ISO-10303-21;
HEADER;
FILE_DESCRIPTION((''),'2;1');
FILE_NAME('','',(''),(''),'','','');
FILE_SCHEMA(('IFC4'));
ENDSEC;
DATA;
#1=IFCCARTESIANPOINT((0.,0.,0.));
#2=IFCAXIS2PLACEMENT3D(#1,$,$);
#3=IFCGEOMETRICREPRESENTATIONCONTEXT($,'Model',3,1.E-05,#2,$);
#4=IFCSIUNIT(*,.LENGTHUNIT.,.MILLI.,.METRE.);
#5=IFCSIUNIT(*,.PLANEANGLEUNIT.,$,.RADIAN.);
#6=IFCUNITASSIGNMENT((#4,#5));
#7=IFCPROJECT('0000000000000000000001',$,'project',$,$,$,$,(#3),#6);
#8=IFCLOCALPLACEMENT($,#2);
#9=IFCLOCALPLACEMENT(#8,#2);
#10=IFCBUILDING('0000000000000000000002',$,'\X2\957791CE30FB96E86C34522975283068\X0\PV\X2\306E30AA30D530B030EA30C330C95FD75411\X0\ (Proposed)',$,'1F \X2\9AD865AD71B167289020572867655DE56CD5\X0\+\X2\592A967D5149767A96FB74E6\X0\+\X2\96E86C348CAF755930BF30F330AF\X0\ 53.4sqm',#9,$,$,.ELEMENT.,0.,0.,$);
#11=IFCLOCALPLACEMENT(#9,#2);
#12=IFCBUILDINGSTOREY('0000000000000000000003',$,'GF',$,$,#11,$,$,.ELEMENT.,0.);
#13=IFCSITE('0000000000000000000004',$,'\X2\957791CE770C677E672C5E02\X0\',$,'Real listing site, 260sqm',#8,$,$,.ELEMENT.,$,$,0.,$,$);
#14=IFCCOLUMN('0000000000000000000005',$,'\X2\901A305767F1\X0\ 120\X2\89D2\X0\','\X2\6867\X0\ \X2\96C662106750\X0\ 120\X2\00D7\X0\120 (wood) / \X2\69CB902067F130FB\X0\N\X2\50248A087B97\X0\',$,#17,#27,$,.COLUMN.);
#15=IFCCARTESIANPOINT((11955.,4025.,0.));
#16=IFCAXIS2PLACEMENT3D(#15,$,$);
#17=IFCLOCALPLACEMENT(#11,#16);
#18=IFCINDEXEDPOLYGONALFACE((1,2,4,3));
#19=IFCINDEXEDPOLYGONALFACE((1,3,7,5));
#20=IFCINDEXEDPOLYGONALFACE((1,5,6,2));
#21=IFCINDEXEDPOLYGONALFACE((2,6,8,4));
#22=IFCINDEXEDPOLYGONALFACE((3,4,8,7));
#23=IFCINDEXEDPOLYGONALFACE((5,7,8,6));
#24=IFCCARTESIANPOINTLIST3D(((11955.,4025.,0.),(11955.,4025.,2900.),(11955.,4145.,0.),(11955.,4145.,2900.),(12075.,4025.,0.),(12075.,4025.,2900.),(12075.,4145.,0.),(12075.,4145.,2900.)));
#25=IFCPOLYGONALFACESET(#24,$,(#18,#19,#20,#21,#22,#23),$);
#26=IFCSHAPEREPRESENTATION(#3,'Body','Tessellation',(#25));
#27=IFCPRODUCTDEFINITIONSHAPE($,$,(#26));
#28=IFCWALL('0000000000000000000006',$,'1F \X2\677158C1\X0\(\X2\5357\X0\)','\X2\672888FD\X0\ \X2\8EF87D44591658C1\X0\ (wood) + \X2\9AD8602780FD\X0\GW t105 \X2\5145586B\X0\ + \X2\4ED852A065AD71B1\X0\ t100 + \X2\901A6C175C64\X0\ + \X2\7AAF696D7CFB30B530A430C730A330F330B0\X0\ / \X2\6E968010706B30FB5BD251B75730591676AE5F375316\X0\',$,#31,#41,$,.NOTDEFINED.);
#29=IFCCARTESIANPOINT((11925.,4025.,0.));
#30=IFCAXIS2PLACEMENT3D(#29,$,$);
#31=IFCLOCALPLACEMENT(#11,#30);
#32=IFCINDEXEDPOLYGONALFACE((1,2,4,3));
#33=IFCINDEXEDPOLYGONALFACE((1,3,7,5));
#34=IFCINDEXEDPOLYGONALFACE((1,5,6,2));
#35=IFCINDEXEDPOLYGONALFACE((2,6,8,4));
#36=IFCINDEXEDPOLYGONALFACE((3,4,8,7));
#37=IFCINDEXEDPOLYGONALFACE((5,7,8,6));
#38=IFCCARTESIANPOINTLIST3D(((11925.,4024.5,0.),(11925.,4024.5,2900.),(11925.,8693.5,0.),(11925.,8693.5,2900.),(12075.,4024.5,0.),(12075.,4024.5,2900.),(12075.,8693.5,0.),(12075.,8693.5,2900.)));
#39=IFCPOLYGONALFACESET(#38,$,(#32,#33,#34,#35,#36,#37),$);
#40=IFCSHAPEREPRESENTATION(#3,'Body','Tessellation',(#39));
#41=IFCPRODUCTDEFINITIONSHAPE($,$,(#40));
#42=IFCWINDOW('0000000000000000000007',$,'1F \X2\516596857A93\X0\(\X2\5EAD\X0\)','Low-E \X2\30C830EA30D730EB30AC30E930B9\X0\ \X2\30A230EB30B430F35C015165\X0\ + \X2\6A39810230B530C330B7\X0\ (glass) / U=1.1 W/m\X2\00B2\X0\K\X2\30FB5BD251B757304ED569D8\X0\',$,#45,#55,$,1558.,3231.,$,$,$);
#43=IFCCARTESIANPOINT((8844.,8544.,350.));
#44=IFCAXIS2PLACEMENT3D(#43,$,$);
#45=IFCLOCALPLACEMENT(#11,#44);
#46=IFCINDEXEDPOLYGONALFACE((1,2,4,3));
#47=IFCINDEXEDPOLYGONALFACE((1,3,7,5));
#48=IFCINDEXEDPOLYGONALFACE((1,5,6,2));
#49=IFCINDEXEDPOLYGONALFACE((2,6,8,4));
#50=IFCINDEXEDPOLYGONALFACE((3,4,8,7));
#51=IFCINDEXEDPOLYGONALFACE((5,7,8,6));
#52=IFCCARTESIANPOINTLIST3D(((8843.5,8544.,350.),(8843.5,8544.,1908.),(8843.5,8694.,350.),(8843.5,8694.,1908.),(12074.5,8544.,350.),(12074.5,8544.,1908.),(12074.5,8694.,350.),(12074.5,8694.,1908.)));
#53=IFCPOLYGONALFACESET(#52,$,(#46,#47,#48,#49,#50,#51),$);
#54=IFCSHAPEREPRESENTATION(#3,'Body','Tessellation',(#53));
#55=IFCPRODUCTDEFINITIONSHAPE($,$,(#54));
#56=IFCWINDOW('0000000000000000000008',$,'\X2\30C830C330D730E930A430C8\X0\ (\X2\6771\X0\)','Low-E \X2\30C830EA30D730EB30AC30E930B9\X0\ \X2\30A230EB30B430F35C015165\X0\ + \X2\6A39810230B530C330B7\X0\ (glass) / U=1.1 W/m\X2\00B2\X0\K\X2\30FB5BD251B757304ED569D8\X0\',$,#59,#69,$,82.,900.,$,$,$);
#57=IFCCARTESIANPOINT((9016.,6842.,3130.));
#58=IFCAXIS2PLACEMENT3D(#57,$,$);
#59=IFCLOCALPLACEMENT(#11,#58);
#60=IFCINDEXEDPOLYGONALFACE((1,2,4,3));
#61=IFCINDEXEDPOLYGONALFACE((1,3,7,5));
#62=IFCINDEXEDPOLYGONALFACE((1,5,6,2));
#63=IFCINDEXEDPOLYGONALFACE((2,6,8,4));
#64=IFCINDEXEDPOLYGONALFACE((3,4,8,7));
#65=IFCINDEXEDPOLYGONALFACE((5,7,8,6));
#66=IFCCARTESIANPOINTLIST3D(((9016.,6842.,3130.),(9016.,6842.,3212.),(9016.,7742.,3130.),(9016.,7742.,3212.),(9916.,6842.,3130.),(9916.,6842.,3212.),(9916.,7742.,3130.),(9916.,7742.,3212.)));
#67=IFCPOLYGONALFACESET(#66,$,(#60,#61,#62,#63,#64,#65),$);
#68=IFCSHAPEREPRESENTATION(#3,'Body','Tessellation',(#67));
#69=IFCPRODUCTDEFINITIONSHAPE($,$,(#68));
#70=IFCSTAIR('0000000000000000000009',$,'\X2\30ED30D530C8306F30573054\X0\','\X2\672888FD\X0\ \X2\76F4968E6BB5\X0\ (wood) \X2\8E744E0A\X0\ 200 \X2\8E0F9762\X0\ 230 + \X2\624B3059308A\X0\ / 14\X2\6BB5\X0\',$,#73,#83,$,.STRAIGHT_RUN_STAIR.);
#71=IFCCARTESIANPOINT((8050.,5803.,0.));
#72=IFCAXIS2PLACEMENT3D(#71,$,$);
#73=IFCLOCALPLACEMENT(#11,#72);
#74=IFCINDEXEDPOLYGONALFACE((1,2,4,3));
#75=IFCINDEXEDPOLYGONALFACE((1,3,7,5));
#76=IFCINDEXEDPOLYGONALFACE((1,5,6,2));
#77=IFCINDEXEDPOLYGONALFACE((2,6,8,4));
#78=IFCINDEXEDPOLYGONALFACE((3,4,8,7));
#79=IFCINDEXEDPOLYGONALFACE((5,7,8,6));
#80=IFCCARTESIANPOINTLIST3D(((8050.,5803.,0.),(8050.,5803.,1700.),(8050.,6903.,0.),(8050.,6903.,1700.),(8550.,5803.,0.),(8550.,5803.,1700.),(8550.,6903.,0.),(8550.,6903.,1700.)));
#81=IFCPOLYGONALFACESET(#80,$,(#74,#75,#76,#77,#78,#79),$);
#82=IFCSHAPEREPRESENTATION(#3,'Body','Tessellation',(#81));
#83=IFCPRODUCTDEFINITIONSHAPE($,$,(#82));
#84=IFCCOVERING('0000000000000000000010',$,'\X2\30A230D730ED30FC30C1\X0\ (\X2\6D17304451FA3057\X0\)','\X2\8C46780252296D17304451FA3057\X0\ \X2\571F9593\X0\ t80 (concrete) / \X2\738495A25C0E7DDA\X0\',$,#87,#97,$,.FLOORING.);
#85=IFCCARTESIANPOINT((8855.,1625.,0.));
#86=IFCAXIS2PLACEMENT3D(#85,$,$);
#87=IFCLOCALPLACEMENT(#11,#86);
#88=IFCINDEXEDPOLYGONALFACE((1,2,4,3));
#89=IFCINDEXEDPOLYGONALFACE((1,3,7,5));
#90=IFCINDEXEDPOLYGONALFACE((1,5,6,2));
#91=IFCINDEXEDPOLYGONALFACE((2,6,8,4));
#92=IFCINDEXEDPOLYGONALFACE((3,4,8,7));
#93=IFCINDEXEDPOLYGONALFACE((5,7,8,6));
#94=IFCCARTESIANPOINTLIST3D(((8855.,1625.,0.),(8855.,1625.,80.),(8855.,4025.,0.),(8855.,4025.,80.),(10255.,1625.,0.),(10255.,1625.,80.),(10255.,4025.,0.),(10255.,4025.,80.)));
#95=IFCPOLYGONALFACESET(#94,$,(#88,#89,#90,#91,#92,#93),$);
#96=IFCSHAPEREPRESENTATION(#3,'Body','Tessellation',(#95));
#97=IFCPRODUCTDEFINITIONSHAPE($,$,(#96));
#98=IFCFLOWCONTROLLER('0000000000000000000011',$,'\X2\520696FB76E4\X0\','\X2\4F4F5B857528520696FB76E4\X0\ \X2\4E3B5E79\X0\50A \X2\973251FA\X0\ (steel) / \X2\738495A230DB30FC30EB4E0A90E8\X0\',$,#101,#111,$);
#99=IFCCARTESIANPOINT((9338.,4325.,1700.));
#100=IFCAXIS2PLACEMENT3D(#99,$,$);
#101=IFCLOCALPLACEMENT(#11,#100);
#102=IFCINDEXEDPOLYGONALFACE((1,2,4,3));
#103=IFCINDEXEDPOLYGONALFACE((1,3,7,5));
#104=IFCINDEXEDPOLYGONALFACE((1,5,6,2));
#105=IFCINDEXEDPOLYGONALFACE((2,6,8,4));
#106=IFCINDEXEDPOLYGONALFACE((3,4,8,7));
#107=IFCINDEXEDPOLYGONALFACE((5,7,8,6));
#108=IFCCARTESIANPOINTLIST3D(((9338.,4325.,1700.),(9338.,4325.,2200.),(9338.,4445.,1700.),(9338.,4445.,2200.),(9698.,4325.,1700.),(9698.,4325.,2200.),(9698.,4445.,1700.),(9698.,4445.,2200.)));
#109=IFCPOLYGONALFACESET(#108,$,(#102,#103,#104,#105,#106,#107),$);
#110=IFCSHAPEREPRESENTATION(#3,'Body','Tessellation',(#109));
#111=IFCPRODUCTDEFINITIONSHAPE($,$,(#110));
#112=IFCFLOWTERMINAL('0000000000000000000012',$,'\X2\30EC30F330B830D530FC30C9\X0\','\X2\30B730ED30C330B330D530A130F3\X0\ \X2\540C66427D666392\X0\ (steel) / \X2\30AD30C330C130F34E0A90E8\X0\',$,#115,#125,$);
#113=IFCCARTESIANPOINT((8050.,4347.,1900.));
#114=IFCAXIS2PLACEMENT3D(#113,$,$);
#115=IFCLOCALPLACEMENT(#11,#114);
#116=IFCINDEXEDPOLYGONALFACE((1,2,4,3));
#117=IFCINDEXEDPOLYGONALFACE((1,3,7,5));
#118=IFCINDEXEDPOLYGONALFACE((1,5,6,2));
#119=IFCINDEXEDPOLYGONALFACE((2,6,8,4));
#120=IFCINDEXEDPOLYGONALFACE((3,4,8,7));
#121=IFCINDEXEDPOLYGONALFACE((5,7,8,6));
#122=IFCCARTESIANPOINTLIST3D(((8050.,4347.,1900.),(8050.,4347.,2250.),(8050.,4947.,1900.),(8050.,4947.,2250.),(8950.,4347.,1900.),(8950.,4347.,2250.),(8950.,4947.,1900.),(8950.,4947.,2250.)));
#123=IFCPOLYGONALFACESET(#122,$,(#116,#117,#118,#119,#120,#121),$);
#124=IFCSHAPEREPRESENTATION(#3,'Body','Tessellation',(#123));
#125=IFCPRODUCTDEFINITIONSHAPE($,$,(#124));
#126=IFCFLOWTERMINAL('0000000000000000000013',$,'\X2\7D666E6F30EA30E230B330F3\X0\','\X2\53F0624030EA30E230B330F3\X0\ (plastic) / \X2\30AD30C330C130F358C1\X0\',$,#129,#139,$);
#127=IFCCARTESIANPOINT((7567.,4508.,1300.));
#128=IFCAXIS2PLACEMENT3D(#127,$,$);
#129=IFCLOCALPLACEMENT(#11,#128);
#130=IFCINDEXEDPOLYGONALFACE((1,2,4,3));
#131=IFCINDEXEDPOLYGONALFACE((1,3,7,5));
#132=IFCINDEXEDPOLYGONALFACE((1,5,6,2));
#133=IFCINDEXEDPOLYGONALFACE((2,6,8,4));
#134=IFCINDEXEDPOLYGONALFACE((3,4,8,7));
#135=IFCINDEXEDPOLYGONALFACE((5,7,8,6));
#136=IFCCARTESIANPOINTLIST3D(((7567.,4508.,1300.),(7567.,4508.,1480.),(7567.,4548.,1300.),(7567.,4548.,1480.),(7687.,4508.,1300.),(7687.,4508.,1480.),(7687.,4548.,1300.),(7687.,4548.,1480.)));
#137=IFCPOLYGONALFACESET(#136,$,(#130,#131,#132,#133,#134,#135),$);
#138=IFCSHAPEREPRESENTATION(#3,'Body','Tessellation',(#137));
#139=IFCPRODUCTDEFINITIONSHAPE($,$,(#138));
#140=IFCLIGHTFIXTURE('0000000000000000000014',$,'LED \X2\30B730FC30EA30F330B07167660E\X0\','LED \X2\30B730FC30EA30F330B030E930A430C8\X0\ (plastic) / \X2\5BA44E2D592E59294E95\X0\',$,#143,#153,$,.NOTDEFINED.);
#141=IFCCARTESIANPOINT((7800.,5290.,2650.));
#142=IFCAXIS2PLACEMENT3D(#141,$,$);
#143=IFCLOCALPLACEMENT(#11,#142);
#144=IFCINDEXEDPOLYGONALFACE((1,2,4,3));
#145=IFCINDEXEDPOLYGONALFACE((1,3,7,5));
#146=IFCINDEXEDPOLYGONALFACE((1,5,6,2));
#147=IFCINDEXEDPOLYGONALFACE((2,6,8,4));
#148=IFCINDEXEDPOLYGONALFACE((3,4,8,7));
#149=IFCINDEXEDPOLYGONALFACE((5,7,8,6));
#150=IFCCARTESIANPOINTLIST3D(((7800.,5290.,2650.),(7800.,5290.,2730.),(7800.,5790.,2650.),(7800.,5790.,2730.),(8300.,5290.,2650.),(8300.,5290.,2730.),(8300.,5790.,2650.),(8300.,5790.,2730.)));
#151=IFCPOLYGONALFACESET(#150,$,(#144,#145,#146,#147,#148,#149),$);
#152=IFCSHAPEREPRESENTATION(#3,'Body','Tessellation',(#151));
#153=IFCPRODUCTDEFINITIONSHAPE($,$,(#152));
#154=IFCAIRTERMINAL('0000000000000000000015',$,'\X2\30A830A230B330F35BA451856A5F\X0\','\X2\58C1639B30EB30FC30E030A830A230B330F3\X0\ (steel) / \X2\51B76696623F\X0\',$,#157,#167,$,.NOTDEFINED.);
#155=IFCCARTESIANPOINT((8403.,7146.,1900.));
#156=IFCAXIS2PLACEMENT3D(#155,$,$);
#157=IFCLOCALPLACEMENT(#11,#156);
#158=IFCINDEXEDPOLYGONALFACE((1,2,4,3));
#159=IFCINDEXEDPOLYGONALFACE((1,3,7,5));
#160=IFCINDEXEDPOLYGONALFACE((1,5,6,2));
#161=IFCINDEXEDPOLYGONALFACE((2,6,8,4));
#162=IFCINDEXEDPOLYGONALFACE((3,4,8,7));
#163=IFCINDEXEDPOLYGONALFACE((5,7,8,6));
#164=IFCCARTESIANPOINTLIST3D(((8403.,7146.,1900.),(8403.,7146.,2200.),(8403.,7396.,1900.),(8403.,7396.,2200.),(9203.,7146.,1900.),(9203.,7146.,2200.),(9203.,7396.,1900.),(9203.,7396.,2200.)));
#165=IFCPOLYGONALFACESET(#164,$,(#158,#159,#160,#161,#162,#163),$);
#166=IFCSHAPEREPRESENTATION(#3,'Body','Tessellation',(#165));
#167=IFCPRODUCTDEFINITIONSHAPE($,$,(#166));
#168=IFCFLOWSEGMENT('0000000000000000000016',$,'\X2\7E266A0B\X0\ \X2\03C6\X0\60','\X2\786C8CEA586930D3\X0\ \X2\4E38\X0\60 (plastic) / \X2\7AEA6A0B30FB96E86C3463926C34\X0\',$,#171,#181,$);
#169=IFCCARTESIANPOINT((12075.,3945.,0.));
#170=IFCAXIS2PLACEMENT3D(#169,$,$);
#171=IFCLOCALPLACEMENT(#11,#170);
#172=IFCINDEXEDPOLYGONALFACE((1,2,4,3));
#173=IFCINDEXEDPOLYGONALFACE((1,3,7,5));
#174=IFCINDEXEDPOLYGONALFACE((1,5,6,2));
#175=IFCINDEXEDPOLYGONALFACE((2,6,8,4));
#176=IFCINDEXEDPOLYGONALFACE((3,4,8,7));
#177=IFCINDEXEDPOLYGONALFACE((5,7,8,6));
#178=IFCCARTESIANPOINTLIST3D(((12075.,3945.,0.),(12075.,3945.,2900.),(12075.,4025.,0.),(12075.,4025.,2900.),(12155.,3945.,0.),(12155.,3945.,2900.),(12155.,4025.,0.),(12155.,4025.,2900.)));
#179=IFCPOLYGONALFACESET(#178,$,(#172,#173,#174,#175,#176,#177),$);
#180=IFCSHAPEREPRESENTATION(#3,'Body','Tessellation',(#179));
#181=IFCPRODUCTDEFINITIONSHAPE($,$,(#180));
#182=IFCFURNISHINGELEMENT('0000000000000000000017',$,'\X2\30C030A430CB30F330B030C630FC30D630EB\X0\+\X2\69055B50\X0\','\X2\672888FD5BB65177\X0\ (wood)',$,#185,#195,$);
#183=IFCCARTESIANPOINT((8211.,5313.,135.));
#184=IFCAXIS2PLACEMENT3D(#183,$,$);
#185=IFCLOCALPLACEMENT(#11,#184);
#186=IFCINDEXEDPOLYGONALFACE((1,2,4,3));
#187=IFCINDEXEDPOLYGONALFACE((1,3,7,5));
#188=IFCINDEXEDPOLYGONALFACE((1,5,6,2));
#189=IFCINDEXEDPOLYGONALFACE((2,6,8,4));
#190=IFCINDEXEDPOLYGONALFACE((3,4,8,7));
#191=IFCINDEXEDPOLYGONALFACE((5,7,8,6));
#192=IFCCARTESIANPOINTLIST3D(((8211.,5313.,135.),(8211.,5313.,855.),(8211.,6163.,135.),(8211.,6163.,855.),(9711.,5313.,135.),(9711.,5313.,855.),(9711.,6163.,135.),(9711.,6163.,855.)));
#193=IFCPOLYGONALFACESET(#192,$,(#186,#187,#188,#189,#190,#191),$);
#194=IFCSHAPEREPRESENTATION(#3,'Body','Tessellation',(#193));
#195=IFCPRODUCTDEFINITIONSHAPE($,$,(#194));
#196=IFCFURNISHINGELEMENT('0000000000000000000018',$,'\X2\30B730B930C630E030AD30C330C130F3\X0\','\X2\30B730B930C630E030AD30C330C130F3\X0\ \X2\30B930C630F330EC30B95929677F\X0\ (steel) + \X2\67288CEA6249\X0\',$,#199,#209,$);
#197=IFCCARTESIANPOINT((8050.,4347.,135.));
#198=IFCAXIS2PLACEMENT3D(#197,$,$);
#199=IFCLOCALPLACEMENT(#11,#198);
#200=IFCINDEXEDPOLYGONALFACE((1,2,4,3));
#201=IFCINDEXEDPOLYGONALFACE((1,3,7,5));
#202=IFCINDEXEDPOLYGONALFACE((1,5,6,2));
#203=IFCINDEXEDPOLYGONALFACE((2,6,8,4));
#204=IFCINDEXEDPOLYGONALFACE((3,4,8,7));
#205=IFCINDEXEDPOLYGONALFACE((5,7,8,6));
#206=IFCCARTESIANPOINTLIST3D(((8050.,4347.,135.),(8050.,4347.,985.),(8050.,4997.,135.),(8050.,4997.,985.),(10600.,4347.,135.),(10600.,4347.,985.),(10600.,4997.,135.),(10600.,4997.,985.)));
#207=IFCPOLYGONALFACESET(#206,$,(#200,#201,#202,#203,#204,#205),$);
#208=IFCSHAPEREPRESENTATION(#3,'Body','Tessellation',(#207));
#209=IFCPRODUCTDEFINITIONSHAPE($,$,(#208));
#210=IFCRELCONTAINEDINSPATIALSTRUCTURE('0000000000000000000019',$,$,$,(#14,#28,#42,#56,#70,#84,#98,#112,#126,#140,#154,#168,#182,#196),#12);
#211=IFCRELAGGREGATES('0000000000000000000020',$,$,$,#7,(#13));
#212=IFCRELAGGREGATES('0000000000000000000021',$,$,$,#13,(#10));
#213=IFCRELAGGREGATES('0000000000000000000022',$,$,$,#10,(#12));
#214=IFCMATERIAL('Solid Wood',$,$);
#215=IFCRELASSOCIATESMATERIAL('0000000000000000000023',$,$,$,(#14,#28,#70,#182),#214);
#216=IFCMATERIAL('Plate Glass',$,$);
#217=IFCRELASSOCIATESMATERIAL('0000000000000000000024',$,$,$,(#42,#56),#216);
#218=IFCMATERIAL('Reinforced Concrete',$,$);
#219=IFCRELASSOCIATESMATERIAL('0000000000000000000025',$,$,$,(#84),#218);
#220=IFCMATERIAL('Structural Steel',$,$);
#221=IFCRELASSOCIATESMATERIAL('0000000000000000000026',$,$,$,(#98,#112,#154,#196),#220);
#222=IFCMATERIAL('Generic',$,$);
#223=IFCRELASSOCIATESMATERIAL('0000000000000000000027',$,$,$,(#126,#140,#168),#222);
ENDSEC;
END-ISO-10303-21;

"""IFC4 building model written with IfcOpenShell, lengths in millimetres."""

from ifc_helpers import new_model, si_unit, frame, frame_2d, origin, place, context, project, spatial, rectangle, extrude, material, element, fill, save


model = new_model("IFC4")

# Units and contexts
model_context = context("Model", 3, precision=1e-05, world=origin())
ifc_project = project(units=[si_unit("LENGTHUNIT", "METRE", prefix="MILLI"), si_unit("PLANEANGLEUNIT", "RADIAN")], contexts=[model_context])

# Site, building, storey
site_placement = place(None, origin())
site = spatial("IfcSite", under=ifc_project, at=site_placement, Name="長野県松本市", ObjectType="Real listing site, 260sqm", CompositionType="ELEMENT", RefElevation=0.0)
building_placement = place(site_placement, origin())
building = spatial("IfcBuilding", under=site, at=building_placement, Name="長野・雨水利用とPVのオフグリッド志向 (Proposed)", ObjectType="1F 高断熱木造在来工法+太陽光発電瓦+雨水貯留タンク 53.4sqm", CompositionType="ELEMENT", ElevationOfRefHeight=0.0, ElevationOfTerrain=0.0)
storey_placement = place(building_placement, origin())
storey = spatial("IfcBuildingStorey", under=building, at=storey_placement, Name="GF", CompositionType="ELEMENT", Elevation=0.0)

# Column
ifc_material_1 = material(Name="Solid Wood")
column_1_placement = place(storey_placement, frame((11955.0, 4025.0, 0.0)))
element("IfcColumn", 1, at=column_1_placement, inside=storey, material=ifc_material_1, Name="通し柱 120角", Description="桧 集成材 120×120 (wood) / 構造柱・N値計算", PredefinedType="COLUMN", context=model_context, shape_type="SweptSolid", body=[
    extrude(rectangle(XDim=120.0, YDim=120.0, at=frame_2d((60.0, 60.0))), frame((11955.0, 4025.0, 0.0)), (0.0, 0.0, 1.0), 2900.0),
])

# Wall, opening, window
wall_1_placement = place(storey_placement, frame((11925.0, 4025.0, 0.0)))
wall_1 = element("IfcWall", 2, at=wall_1_placement, inside=storey, material=ifc_material_1, Name="1F 東壁(南)", Description="木製 軸組外壁 (wood) + 高性能GW t105 充填 + 付加断熱 t100 + 通気層 + 窯業系サイディング / 準耐火・寒冷地外皮強化", PredefinedType="NOTDEFINED", context=model_context, shape_type="SweptSolid", body=[
    extrude(rectangle(XDim=150.0, YDim=4669.0, at=frame_2d((75.0, 2334.0))), frame((11925.0, 4025.0, 0.0)), (0.0, 0.0, 1.0), 2900.0),
])
opening_1_placement = place(storey_placement, frame((8844.0, 8544.0, 350.0)))
opening_1 = element("IfcOpeningElement", 3, at=opening_1_placement, cuts=wall_1, PredefinedType="NOTDEFINED", context=model_context, shape_type="SweptSolid", body=[
    extrude(rectangle(XDim=3231.0, YDim=150.0, at=frame_2d((1615.0, 75.0))), frame((8844.0, 8544.0, 350.0)), (0.0, 0.0, 1.0), 1558.0),
])
ifc_material_2 = material(Name="Plate Glass")
window_1_placement = place(storey_placement, frame((8844.0, 8544.0, 350.0)))
window_1 = element("IfcWindow", 4, at=window_1_placement, inside=storey, material=ifc_material_2, Name="1F 入隅窓(庭)", Description="Low-E トリプルガラス アルゴン封入 + 樹脂サッシ (glass) / U=1.1 W/m²K・寒冷地仕様", OverallHeight=1558.0, OverallWidth=3231.0, context=model_context, shape_type="SweptSolid", body=[
    extrude(rectangle(XDim=3231.0, YDim=150.0, at=frame_2d((1615.0, 75.0))), frame((8844.0, 8544.0, 350.0)), (0.0, 0.0, 1.0), 1558.0),
])
fill(opening_1, window_1)

# Window
window_2_placement = place(storey_placement, frame((9016.0, 6842.0, 3130.0)))
element("IfcWindow", 5, at=window_2_placement, inside=storey, material=ifc_material_2, Name="トップライト (東)", Description="Low-E トリプルガラス アルゴン封入 + 樹脂サッシ (glass) / U=1.1 W/m²K・寒冷地仕様", OverallHeight=82.0, OverallWidth=900.0, context=model_context, shape_type="SweptSolid", body=[
    extrude(rectangle(XDim=900.0, YDim=900.0, at=frame_2d((450.0, 450.0))), frame((9016.0, 6842.0, 3130.0)), (0.0, 0.0, 1.0), 82.0),
])

# Stair
stair_placement = place(storey_placement, frame((8050.0, 5803.0, 0.0)))
element("IfcStair", 6, at=stair_placement, inside=storey, material=ifc_material_1, Name="ロフトはしご", Description="木製 直階段 (wood) 蹴上 200 踏面 230 + 手すり / 14段", PredefinedType="STRAIGHT_RUN_STAIR", context=model_context, shape_type="SweptSolid", body=[
    extrude(rectangle(XDim=500.0, YDim=1100.0, at=frame_2d((250.0, 550.0))), frame((8050.0, 5803.0, 0.0)), (0.0, 0.0, 1.0), 1700.0),
])

# Covering
ifc_material_3 = material(Name="Reinforced Concrete")
covering_placement = place(storey_placement, frame((8855.0, 1625.0, 0.0)))
element("IfcCovering", 7, at=covering_placement, inside=storey, material=ifc_material_3, Name="アプローチ (洗い出し)", Description="豆砂利洗い出し 土間 t80 (concrete) / 玄関導線", PredefinedType="FLOORING", context=model_context, shape_type="SweptSolid", body=[
    extrude(rectangle(XDim=1400.0, YDim=2400.0, at=frame_2d((700.0, 1200.0))), frame((8855.0, 1625.0, 0.0)), (0.0, 0.0, 1.0), 80.0),
])

# Flow controller
ifc_material_4 = material(Name="Structural Steel")
flow_controller_placement = place(storey_placement, frame((9338.0, 4325.0, 1700.0)))
element("IfcFlowController", 8, at=flow_controller_placement, inside=storey, material=ifc_material_4, Name="分電盤", Description="住宅用分電盤 主幹50A 露出 (steel) / 玄関ホール上部", context=model_context, shape_type="SweptSolid", body=[
    extrude(rectangle(XDim=360.0, YDim=120.0, at=frame_2d((180.0, 60.0))), frame((9338.0, 4325.0, 1700.0)), (0.0, 0.0, 1.0), 500.0),
])

# Flow terminals
flow_terminal_1_placement = place(storey_placement, frame((8050.0, 4347.0, 1900.0)))
element("IfcFlowTerminal", 9, at=flow_terminal_1_placement, inside=storey, material=ifc_material_4, Name="レンジフード", Description="シロッコファン 同時給排 (steel) / キッチン上部", context=model_context, shape_type="SweptSolid", body=[
    extrude(rectangle(XDim=900.0, YDim=600.0, at=frame_2d((450.0, 300.0))), frame((8050.0, 4347.0, 1900.0)), (0.0, 0.0, 1.0), 350.0),
])
ifc_material_5 = material(Name="Generic")
flow_terminal_2_placement = place(storey_placement, frame((7567.0, 4508.0, 1300.0)))
element("IfcFlowTerminal", 10, at=flow_terminal_2_placement, inside=storey, material=ifc_material_5, Name="給湯リモコン", Description="台所リモコン (plastic) / キッチン壁", context=model_context, shape_type="SweptSolid", body=[
    extrude(rectangle(XDim=120.0, YDim=40.0, at=frame_2d((60.0, 20.0))), frame((7567.0, 4508.0, 1300.0)), (0.0, 0.0, 1.0), 180.0),
])

# Light fixture
light_fixture_placement = place(storey_placement, frame((7800.0, 5290.0, 2650.0)))
element("IfcLightFixture", 11, at=light_fixture_placement, inside=storey, material=ifc_material_5, Name="LED シーリング照明", Description="LED シーリングライト (plastic) / 室中央天井", PredefinedType="NOTDEFINED", context=model_context, shape_type="SweptSolid", body=[
    extrude(rectangle(XDim=500.0, YDim=500.0, at=frame_2d((250.0, 250.0))), frame((7800.0, 5290.0, 2650.0)), (0.0, 0.0, 1.0), 80.0),
])

# Air terminal
air_terminal_placement = place(storey_placement, frame((8403.0, 7146.0, 1900.0)))
element("IfcAirTerminal", 12, at=air_terminal_placement, inside=storey, material=ifc_material_4, Name="エアコン室内機", Description="壁掛ルームエアコン (steel) / 冷暖房", PredefinedType="NOTDEFINED", context=model_context, shape_type="SweptSolid", body=[
    extrude(rectangle(XDim=800.0, YDim=250.0, at=frame_2d((400.0, 125.0))), frame((8403.0, 7146.0, 1900.0)), (0.0, 0.0, 1.0), 300.0),
])

# Flow segment
flow_segment_placement = place(storey_placement, frame((12075.0, 3945.0, 0.0)))
element("IfcFlowSegment", 13, at=flow_segment_placement, inside=storey, material=ifc_material_5, Name="縦樋 φ60", Description="硬質塩ビ 丸60 (plastic) / 竪樋・雨水排水", context=model_context, shape_type="SweptSolid", body=[
    extrude(rectangle(XDim=80.0, YDim=80.0, at=frame_2d((40.0, 40.0))), frame((12075.0, 3945.0, 0.0)), (0.0, 0.0, 1.0), 2900.0),
])

# Furnishing elements
furnishing_1_placement = place(storey_placement, frame((8211.0, 5313.0, 135.0)))
element("IfcFurnishingElement", 14, at=furnishing_1_placement, inside=storey, material=ifc_material_1, Name="ダイニングテーブル+椅子", Description="木製家具 (wood)", context=model_context, shape_type="SweptSolid", body=[
    extrude(rectangle(XDim=1500.0, YDim=850.0, at=frame_2d((750.0, 425.0))), frame((8211.0, 5313.0, 135.0)), (0.0, 0.0, 1.0), 720.0),
])
furnishing_2_placement = place(storey_placement, frame((8050.0, 4347.0, 135.0)))
element("IfcFurnishingElement", 15, at=furnishing_2_placement, inside=storey, material=ifc_material_4, Name="システムキッチン", Description="システムキッチン ステンレス天板 (steel) + 木質扉", context=model_context, shape_type="SweptSolid", body=[
    extrude(rectangle(XDim=2550.0, YDim=650.0, at=frame_2d((1275.0, 325.0))), frame((8050.0, 4347.0, 135.0)), (0.0, 0.0, 1.0), 850.0),
])

save(model, "model.ifc")
